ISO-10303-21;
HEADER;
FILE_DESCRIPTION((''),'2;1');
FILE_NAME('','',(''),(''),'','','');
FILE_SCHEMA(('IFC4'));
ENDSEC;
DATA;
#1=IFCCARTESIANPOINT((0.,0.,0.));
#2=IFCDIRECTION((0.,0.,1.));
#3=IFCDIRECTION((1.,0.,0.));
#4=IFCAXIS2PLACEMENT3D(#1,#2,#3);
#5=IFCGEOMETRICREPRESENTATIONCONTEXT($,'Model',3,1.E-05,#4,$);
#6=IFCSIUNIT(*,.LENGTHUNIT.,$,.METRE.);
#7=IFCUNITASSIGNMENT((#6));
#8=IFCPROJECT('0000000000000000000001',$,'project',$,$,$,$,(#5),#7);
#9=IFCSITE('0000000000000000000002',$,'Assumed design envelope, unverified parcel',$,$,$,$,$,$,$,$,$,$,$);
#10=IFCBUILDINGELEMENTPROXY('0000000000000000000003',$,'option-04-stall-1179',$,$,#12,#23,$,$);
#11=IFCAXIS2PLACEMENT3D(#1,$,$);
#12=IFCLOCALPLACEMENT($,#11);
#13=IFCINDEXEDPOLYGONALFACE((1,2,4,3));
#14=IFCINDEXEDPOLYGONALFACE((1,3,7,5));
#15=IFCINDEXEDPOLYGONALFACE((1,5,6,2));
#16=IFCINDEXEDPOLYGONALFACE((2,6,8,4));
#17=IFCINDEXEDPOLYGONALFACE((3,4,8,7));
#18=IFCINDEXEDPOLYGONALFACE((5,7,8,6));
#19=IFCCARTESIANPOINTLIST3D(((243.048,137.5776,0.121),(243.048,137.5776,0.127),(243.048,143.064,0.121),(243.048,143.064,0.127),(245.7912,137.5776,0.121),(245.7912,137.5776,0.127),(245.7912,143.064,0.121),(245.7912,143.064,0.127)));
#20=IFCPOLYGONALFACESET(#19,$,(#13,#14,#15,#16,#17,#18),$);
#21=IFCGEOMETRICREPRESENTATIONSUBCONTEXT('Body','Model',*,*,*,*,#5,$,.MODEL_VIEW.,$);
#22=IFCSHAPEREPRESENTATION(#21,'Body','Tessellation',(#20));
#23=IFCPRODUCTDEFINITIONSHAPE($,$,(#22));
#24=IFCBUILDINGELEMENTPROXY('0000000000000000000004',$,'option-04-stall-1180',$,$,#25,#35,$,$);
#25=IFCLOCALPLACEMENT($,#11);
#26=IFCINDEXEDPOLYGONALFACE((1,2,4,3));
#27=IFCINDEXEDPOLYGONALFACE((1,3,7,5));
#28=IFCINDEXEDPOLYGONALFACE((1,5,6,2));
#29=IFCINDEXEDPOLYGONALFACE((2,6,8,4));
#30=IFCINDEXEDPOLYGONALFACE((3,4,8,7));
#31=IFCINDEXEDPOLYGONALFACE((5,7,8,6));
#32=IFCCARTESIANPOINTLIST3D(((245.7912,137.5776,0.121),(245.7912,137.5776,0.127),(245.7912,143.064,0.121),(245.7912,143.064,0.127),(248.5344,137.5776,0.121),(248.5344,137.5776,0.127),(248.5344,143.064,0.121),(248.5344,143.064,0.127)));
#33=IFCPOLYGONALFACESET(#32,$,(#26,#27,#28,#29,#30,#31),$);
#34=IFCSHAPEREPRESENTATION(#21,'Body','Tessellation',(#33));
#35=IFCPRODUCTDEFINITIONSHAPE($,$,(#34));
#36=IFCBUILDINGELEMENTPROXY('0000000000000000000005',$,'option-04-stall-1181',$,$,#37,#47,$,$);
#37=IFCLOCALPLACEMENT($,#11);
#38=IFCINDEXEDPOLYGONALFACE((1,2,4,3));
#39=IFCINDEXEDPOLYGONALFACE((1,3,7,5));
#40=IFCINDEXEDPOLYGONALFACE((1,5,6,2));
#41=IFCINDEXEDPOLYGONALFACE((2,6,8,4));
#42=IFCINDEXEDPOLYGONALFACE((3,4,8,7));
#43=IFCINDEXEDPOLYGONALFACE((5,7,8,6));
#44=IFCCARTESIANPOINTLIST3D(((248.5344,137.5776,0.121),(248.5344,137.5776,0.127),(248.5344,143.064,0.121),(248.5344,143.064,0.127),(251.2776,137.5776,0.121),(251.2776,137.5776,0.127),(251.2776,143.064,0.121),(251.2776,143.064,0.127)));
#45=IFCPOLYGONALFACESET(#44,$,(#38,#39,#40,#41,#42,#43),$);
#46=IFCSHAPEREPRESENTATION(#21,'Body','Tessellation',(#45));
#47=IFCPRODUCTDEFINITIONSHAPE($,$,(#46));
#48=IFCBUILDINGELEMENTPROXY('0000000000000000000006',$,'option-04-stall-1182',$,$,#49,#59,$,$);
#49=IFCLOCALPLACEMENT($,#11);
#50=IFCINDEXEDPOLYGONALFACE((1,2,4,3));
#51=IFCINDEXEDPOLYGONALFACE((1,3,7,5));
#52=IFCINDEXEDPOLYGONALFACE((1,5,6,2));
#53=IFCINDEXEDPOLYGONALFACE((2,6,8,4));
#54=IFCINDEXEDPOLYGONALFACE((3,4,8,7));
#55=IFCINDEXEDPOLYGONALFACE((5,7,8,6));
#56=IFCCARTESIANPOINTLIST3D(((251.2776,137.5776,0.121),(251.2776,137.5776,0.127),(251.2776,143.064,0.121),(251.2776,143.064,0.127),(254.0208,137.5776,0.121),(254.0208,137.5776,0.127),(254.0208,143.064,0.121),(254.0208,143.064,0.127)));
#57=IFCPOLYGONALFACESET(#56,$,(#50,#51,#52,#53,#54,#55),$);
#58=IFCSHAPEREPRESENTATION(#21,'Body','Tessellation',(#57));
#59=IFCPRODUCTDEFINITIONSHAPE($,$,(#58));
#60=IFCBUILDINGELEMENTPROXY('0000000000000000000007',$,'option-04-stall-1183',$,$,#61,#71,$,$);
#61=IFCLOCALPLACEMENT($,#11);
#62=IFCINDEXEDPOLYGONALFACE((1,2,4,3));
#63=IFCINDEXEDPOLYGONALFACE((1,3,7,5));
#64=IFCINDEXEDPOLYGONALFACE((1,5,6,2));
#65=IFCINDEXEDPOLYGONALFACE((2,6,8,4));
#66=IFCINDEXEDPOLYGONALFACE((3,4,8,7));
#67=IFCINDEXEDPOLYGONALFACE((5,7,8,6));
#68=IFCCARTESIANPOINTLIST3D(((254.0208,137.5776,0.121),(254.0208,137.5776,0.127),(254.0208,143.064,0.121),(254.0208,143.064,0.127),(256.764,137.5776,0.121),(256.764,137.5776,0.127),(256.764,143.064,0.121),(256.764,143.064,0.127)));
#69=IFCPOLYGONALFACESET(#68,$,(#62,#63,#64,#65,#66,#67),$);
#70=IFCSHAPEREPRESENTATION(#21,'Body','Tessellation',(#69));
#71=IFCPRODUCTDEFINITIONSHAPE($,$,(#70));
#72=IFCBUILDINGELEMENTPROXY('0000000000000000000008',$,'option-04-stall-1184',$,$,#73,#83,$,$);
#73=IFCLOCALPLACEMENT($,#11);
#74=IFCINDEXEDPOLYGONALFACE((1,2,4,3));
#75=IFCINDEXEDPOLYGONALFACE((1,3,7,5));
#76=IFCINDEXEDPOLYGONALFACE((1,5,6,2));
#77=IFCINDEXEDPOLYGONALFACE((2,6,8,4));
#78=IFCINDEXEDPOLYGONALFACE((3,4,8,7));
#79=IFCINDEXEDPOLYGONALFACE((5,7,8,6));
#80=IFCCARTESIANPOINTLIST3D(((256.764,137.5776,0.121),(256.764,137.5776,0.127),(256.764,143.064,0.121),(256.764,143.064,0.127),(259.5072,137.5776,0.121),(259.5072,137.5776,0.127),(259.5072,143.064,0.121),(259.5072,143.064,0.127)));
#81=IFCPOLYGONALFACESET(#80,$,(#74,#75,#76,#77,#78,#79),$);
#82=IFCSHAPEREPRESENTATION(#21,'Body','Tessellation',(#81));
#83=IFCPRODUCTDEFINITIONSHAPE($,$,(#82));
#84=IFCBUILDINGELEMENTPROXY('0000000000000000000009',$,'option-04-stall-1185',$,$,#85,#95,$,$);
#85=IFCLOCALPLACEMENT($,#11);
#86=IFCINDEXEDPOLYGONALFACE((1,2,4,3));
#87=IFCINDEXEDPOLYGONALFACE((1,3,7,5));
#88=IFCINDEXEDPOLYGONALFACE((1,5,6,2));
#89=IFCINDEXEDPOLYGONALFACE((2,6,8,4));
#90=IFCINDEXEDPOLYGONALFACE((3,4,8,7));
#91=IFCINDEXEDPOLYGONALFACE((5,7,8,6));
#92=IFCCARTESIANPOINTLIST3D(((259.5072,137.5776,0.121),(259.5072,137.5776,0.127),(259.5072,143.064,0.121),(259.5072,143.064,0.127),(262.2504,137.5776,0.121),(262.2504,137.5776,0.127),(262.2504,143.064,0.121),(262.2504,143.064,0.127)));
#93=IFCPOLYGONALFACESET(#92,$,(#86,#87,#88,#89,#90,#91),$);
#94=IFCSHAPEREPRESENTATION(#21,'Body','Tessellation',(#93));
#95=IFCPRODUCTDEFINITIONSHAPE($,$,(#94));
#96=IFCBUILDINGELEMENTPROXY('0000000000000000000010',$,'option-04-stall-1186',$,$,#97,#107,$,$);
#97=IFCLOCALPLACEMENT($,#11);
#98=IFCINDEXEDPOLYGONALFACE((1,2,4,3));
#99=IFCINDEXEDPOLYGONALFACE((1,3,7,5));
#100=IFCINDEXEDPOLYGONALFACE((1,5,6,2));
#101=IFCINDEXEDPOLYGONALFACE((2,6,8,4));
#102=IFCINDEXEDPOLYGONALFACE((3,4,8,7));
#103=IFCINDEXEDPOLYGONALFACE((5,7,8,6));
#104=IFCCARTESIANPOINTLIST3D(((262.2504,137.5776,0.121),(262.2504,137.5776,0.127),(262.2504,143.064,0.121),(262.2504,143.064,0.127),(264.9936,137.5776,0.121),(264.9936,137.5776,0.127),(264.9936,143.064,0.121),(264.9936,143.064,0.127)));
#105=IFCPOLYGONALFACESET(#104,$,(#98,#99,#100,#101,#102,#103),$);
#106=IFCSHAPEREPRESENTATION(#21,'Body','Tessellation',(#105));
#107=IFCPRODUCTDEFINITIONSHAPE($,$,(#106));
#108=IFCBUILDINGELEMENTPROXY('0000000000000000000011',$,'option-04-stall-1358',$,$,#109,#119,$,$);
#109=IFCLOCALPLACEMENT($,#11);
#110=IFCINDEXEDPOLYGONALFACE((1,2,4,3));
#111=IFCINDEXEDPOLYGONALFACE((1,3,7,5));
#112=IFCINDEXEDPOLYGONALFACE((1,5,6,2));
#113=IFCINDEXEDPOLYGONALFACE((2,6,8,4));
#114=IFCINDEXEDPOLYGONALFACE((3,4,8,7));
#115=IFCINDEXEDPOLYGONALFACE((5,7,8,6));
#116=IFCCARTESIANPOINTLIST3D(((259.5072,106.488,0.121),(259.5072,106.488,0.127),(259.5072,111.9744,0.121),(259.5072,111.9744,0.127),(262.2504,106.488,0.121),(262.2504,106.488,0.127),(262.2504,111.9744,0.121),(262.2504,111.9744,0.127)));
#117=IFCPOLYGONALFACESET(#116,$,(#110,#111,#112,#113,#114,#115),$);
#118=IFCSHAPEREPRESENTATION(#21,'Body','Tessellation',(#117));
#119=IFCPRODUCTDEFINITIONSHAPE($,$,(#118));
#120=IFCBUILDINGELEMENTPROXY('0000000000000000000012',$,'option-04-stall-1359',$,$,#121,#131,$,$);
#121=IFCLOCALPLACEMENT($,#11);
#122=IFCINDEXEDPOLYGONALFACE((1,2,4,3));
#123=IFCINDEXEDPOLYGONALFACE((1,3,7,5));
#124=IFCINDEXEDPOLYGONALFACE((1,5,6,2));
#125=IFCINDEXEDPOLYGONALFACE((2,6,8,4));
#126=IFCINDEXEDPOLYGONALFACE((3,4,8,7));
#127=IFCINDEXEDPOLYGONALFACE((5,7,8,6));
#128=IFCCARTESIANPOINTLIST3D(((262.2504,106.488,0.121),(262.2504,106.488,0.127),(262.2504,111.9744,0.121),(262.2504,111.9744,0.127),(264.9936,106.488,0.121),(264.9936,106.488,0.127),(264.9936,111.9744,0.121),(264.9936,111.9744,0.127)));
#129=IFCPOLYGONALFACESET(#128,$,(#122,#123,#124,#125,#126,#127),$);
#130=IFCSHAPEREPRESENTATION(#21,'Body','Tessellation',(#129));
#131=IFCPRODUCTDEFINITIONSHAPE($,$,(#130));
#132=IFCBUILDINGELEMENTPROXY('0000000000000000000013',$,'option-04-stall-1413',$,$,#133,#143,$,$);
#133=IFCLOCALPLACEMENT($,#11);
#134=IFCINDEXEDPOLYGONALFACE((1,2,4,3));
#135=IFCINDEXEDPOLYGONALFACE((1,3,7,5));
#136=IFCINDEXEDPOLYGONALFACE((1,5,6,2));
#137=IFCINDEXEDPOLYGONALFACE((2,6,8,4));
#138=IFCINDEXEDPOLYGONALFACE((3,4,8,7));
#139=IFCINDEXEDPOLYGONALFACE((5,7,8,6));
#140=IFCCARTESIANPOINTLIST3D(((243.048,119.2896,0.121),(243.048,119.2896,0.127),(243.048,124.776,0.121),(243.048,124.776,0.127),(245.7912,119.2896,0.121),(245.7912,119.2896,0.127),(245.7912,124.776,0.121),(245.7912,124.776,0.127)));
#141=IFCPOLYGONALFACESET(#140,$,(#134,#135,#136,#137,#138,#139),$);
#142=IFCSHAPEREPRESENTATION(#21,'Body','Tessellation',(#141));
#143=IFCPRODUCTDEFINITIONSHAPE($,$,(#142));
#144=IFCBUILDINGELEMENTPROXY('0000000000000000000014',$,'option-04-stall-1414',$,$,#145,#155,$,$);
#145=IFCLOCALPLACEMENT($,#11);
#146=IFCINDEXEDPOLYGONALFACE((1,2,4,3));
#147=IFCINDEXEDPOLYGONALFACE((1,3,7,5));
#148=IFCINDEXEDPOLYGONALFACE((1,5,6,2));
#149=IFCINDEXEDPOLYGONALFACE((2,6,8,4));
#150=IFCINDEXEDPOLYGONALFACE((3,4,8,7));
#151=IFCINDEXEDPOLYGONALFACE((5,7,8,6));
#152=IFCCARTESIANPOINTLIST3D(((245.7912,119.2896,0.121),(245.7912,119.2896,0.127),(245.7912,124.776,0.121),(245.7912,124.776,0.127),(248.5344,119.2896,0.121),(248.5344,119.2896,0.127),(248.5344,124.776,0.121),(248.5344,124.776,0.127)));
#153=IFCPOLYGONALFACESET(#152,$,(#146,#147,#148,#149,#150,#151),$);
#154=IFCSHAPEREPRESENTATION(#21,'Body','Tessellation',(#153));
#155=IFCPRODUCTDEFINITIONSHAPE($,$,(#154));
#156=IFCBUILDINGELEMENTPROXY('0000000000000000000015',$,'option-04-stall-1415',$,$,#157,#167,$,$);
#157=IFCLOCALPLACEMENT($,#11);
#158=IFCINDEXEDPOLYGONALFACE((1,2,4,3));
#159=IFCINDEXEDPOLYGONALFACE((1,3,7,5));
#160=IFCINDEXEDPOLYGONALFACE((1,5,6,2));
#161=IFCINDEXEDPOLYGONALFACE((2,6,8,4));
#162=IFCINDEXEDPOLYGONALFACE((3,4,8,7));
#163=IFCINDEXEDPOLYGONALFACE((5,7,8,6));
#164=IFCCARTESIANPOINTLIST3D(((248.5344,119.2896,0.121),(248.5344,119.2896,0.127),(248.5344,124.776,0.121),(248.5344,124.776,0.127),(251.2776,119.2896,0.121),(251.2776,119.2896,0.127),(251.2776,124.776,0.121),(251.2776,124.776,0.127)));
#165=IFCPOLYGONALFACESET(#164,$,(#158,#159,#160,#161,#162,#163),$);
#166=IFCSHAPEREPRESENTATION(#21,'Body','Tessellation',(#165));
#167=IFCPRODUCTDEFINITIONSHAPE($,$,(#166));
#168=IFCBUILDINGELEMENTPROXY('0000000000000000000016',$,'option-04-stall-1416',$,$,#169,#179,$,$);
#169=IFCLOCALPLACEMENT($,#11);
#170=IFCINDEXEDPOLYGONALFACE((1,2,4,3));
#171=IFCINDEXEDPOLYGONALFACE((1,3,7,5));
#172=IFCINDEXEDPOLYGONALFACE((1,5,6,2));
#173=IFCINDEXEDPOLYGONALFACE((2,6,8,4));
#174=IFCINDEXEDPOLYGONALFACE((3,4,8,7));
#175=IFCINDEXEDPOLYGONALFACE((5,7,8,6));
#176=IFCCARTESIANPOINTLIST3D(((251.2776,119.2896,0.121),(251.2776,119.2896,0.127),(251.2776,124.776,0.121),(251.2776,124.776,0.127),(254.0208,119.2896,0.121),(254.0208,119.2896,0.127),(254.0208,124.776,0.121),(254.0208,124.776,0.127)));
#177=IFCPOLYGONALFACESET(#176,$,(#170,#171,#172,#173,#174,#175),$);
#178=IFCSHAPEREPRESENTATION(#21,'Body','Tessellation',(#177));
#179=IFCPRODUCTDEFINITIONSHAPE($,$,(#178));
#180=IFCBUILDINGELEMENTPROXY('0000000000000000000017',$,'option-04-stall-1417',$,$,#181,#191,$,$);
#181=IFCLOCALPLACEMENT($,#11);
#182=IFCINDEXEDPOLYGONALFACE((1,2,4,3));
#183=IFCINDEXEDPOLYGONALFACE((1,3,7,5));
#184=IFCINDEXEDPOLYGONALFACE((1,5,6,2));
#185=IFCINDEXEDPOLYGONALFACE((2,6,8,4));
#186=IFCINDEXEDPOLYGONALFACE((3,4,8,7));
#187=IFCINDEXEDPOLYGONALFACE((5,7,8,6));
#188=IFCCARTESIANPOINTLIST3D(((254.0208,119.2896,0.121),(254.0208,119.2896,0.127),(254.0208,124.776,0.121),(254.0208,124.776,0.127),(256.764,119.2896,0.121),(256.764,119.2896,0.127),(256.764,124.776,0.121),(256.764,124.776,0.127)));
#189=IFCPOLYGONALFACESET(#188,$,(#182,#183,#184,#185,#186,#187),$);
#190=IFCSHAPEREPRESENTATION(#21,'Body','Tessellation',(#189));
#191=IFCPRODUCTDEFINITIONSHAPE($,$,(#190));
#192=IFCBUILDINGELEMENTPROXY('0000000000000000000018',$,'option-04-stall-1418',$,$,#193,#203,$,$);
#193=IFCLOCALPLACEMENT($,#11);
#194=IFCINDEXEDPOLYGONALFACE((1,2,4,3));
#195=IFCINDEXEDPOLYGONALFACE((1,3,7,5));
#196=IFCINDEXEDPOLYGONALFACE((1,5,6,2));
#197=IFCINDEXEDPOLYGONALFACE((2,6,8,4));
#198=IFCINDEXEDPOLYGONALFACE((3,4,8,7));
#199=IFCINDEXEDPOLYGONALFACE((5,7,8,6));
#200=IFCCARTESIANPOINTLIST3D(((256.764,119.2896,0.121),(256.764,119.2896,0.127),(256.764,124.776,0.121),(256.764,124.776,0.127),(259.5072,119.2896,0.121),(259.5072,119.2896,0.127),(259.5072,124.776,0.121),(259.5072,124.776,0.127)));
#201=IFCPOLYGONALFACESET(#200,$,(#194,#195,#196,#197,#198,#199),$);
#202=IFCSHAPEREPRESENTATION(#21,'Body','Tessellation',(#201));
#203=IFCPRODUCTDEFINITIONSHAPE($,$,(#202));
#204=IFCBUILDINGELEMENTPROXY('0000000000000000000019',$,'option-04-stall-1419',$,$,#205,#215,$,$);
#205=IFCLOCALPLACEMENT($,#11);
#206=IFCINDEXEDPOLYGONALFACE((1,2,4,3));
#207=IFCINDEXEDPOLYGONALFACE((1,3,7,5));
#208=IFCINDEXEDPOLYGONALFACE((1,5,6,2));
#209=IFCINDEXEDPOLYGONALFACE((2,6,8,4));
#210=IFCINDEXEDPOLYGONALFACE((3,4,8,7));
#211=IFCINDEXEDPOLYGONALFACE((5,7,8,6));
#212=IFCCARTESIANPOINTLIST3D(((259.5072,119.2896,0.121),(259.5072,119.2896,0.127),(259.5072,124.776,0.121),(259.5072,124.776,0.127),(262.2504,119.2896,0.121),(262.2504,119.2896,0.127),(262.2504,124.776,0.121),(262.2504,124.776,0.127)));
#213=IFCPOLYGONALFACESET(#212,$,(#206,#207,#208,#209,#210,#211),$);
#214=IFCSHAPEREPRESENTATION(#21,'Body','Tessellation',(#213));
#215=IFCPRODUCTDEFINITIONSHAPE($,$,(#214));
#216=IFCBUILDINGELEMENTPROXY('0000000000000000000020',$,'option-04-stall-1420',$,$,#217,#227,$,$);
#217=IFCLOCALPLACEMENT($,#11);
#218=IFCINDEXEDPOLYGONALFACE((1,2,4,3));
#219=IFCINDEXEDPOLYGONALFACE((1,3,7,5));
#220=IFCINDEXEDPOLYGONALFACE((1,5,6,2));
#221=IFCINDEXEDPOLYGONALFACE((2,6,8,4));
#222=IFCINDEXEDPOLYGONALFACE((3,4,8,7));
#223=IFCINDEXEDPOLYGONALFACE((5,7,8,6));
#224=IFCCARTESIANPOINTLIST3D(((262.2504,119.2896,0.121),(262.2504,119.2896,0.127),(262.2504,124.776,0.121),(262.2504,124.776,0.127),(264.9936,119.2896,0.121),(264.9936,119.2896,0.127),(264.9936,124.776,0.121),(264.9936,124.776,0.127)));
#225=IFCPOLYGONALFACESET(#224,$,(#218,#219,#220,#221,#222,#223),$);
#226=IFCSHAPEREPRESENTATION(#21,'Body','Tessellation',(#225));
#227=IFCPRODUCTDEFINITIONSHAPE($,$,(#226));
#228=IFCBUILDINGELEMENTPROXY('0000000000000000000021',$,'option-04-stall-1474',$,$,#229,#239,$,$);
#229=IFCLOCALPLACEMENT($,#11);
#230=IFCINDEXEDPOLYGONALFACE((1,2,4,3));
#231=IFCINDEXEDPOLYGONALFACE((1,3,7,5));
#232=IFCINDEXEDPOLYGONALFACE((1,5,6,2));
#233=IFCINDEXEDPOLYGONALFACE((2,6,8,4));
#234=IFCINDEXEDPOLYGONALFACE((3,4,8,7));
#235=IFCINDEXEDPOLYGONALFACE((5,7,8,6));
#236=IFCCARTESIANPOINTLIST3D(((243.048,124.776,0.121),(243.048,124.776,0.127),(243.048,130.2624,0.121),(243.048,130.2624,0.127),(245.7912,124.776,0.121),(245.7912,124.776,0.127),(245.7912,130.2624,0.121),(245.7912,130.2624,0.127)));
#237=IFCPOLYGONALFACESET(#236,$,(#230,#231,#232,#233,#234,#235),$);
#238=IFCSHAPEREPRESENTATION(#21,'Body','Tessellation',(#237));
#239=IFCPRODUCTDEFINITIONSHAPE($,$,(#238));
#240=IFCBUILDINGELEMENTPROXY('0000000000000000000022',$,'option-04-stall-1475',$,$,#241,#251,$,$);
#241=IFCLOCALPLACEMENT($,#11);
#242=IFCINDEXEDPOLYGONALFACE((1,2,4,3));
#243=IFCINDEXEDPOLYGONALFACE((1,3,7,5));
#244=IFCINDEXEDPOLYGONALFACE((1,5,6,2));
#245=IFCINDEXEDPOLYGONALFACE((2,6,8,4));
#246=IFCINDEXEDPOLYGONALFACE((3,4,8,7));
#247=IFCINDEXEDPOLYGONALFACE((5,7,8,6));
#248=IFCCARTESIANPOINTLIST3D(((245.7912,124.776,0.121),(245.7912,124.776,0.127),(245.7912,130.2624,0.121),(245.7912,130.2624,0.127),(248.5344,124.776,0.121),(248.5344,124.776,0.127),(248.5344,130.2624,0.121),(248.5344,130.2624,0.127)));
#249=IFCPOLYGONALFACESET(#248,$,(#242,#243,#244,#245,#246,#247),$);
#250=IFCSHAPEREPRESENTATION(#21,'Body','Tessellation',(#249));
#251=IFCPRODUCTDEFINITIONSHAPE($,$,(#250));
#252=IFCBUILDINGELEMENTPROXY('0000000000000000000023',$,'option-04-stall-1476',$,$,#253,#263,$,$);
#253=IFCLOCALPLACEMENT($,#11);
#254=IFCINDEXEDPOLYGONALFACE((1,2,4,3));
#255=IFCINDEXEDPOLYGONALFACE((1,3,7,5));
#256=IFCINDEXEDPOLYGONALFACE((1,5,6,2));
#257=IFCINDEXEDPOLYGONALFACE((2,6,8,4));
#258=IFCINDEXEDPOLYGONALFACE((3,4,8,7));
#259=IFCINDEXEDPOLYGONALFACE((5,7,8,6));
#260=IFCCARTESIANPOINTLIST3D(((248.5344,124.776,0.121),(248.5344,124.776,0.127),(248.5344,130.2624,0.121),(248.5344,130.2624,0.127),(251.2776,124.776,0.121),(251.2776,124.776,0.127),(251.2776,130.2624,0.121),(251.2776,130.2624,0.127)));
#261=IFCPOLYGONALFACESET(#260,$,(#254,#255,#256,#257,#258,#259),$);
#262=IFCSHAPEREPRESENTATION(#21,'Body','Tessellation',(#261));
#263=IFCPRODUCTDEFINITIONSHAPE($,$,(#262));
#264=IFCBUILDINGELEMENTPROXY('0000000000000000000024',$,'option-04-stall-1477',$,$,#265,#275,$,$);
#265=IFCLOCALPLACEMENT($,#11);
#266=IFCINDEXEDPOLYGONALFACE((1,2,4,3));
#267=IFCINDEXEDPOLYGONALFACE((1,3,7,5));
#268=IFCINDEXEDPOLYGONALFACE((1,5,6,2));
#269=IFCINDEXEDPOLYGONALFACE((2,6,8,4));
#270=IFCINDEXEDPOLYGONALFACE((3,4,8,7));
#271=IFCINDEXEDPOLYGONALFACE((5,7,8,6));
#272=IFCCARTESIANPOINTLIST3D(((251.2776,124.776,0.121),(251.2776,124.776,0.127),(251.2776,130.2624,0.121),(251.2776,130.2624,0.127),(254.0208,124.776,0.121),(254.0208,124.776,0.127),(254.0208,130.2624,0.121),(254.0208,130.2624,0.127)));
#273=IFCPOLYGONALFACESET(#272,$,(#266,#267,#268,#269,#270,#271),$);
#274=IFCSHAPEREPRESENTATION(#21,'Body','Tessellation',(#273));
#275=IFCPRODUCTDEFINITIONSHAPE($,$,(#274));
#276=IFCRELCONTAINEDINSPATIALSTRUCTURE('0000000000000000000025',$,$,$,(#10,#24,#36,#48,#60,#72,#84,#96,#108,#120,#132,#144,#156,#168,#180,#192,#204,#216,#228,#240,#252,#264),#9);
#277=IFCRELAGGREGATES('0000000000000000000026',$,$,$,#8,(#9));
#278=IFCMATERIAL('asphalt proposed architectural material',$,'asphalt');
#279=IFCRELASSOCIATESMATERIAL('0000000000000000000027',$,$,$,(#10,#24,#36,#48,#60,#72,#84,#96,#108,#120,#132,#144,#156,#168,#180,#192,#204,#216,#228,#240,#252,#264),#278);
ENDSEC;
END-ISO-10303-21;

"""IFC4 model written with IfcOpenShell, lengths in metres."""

from ifc_helpers import new_model, si_unit, frame, origin_with_axes, place, context, subcontext, project, spatial, rectangle, extrude, material, element, save


model = new_model("IFC4")

# Units and contexts
model_context = context("Model", 3, precision=1e-05, world=origin_with_axes())
body_context = subcontext(model_context, "Body", "Model", "MODEL_VIEW")
ifc_project = project(units=[si_unit("LENGTHUNIT", "METRE")], contexts=[model_context])

# Site
site = spatial("IfcSite", under=ifc_project, Name="Assumed design envelope, unverified parcel")

# Building element proxies
ifc_material = material(Name="asphalt proposed architectural material", Category="asphalt")
for number, where, z_axis, x_axis, name in (
    (1, (244.4196, 140.3208, 0.121), (0.0, 0.0, 1.0), (1.0, 0.0, 0.0), "option-04-stall-1179"),
    (2, (247.1628, 140.3208, 0.121), (0.0, 0.0, 1.0), (1.0, 0.0, 0.0), "option-04-stall-1180"),
    (3, (249.906, 140.3208, 0.121), (0.0, 0.0, 1.0), (1.0, 0.0, 0.0), "option-04-stall-1181"),
    (4, (252.6492, 140.3208, 0.121), (0.0, 0.0, 1.0), (1.0, 0.0, 0.0), "option-04-stall-1182"),
    (5, (255.3924, 140.3208, 0.121), (0.0, 0.0, 1.0), (1.0, 0.0, 0.0), "option-04-stall-1183"),
    (6, (258.1356, 140.3208, 0.121), (0.0, 0.0, 1.0), (1.0, 0.0, 0.0), "option-04-stall-1184"),
    (7, (260.8788, 140.3208, 0.121), (0.0, 0.0, 1.0), (1.0, 0.0, 0.0), "option-04-stall-1185"),
    (8, (263.622, 140.3208, 0.121), (0.0, 0.0, 1.0), (1.0, 0.0, 0.0), "option-04-stall-1186"),
    (9, (260.8788, 109.2312, 0.121), (0.0, 0.0, 1.0), (1.0, 0.0, 0.0), "option-04-stall-1358"),
    (10, (263.622, 109.2312, 0.121), (0.0, 0.0, 1.0), (1.0, 0.0, 0.0), "option-04-stall-1359"),
    (11, (244.4196, 122.0328, 0.121), (0.0, 0.0, 1.0), (1.0, 0.0, 0.0), "option-04-stall-1413"),
    (12, (247.1628, 122.0328, 0.121), (0.0, 0.0, 1.0), (1.0, 0.0, 0.0), "option-04-stall-1414"),
    (13, (249.906, 122.0328, 0.121), (0.0, 0.0, 1.0), (1.0, 0.0, 0.0), "option-04-stall-1415"),
    (14, (252.6492, 122.0328, 0.121), (0.0, 0.0, 1.0), (1.0, 0.0, 0.0), "option-04-stall-1416"),
    (15, (255.3924, 122.0328, 0.121), (0.0, 0.0, 1.0), (1.0, 0.0, 0.0), "option-04-stall-1417"),
    (16, (258.1356, 122.0328, 0.121), (0.0, 0.0, 1.0), (1.0, 0.0, 0.0), "option-04-stall-1418"),
    (17, (260.8788, 122.0328, 0.121), (0.0, 0.0, 1.0), (1.0, 0.0, 0.0), "option-04-stall-1419"),
    (18, (263.622, 122.0328, 0.121), (0.0, 0.0, 1.0), (1.0, 0.0, 0.0), "option-04-stall-1420"),
    (19, (244.4196, 127.5192, 0.121), (0.0, 0.0, 1.0), (1.0, 0.0, 0.0), "option-04-stall-1474"),
    (20, (247.1628, 127.5192, 0.121), (0.0, 0.0, 1.0), (1.0, 0.0, 0.0), "option-04-stall-1475"),
    (21, (249.906, 127.5192, 0.121), (0.0, 0.0, 1.0), (1.0, 0.0, 0.0), "option-04-stall-1476"),
    (22, (252.6492, 127.5192, 0.121), (0.0, 0.0, 1.0), (1.0, 0.0, 0.0), "option-04-stall-1477"),
):
    element("IfcBuildingElementProxy", number, at=place(None, frame(where, z_axis=z_axis, x_axis=x_axis)), inside=site, material=ifc_material, Name=name, context=body_context, shape_type="SweptSolid", body=[
        extrude(rectangle(XDim=2.7432, YDim=5.4864), origin_with_axes(), (0.0, 0.0, 1.0), 0.006),
    ])

save(model, "model.ifc")
